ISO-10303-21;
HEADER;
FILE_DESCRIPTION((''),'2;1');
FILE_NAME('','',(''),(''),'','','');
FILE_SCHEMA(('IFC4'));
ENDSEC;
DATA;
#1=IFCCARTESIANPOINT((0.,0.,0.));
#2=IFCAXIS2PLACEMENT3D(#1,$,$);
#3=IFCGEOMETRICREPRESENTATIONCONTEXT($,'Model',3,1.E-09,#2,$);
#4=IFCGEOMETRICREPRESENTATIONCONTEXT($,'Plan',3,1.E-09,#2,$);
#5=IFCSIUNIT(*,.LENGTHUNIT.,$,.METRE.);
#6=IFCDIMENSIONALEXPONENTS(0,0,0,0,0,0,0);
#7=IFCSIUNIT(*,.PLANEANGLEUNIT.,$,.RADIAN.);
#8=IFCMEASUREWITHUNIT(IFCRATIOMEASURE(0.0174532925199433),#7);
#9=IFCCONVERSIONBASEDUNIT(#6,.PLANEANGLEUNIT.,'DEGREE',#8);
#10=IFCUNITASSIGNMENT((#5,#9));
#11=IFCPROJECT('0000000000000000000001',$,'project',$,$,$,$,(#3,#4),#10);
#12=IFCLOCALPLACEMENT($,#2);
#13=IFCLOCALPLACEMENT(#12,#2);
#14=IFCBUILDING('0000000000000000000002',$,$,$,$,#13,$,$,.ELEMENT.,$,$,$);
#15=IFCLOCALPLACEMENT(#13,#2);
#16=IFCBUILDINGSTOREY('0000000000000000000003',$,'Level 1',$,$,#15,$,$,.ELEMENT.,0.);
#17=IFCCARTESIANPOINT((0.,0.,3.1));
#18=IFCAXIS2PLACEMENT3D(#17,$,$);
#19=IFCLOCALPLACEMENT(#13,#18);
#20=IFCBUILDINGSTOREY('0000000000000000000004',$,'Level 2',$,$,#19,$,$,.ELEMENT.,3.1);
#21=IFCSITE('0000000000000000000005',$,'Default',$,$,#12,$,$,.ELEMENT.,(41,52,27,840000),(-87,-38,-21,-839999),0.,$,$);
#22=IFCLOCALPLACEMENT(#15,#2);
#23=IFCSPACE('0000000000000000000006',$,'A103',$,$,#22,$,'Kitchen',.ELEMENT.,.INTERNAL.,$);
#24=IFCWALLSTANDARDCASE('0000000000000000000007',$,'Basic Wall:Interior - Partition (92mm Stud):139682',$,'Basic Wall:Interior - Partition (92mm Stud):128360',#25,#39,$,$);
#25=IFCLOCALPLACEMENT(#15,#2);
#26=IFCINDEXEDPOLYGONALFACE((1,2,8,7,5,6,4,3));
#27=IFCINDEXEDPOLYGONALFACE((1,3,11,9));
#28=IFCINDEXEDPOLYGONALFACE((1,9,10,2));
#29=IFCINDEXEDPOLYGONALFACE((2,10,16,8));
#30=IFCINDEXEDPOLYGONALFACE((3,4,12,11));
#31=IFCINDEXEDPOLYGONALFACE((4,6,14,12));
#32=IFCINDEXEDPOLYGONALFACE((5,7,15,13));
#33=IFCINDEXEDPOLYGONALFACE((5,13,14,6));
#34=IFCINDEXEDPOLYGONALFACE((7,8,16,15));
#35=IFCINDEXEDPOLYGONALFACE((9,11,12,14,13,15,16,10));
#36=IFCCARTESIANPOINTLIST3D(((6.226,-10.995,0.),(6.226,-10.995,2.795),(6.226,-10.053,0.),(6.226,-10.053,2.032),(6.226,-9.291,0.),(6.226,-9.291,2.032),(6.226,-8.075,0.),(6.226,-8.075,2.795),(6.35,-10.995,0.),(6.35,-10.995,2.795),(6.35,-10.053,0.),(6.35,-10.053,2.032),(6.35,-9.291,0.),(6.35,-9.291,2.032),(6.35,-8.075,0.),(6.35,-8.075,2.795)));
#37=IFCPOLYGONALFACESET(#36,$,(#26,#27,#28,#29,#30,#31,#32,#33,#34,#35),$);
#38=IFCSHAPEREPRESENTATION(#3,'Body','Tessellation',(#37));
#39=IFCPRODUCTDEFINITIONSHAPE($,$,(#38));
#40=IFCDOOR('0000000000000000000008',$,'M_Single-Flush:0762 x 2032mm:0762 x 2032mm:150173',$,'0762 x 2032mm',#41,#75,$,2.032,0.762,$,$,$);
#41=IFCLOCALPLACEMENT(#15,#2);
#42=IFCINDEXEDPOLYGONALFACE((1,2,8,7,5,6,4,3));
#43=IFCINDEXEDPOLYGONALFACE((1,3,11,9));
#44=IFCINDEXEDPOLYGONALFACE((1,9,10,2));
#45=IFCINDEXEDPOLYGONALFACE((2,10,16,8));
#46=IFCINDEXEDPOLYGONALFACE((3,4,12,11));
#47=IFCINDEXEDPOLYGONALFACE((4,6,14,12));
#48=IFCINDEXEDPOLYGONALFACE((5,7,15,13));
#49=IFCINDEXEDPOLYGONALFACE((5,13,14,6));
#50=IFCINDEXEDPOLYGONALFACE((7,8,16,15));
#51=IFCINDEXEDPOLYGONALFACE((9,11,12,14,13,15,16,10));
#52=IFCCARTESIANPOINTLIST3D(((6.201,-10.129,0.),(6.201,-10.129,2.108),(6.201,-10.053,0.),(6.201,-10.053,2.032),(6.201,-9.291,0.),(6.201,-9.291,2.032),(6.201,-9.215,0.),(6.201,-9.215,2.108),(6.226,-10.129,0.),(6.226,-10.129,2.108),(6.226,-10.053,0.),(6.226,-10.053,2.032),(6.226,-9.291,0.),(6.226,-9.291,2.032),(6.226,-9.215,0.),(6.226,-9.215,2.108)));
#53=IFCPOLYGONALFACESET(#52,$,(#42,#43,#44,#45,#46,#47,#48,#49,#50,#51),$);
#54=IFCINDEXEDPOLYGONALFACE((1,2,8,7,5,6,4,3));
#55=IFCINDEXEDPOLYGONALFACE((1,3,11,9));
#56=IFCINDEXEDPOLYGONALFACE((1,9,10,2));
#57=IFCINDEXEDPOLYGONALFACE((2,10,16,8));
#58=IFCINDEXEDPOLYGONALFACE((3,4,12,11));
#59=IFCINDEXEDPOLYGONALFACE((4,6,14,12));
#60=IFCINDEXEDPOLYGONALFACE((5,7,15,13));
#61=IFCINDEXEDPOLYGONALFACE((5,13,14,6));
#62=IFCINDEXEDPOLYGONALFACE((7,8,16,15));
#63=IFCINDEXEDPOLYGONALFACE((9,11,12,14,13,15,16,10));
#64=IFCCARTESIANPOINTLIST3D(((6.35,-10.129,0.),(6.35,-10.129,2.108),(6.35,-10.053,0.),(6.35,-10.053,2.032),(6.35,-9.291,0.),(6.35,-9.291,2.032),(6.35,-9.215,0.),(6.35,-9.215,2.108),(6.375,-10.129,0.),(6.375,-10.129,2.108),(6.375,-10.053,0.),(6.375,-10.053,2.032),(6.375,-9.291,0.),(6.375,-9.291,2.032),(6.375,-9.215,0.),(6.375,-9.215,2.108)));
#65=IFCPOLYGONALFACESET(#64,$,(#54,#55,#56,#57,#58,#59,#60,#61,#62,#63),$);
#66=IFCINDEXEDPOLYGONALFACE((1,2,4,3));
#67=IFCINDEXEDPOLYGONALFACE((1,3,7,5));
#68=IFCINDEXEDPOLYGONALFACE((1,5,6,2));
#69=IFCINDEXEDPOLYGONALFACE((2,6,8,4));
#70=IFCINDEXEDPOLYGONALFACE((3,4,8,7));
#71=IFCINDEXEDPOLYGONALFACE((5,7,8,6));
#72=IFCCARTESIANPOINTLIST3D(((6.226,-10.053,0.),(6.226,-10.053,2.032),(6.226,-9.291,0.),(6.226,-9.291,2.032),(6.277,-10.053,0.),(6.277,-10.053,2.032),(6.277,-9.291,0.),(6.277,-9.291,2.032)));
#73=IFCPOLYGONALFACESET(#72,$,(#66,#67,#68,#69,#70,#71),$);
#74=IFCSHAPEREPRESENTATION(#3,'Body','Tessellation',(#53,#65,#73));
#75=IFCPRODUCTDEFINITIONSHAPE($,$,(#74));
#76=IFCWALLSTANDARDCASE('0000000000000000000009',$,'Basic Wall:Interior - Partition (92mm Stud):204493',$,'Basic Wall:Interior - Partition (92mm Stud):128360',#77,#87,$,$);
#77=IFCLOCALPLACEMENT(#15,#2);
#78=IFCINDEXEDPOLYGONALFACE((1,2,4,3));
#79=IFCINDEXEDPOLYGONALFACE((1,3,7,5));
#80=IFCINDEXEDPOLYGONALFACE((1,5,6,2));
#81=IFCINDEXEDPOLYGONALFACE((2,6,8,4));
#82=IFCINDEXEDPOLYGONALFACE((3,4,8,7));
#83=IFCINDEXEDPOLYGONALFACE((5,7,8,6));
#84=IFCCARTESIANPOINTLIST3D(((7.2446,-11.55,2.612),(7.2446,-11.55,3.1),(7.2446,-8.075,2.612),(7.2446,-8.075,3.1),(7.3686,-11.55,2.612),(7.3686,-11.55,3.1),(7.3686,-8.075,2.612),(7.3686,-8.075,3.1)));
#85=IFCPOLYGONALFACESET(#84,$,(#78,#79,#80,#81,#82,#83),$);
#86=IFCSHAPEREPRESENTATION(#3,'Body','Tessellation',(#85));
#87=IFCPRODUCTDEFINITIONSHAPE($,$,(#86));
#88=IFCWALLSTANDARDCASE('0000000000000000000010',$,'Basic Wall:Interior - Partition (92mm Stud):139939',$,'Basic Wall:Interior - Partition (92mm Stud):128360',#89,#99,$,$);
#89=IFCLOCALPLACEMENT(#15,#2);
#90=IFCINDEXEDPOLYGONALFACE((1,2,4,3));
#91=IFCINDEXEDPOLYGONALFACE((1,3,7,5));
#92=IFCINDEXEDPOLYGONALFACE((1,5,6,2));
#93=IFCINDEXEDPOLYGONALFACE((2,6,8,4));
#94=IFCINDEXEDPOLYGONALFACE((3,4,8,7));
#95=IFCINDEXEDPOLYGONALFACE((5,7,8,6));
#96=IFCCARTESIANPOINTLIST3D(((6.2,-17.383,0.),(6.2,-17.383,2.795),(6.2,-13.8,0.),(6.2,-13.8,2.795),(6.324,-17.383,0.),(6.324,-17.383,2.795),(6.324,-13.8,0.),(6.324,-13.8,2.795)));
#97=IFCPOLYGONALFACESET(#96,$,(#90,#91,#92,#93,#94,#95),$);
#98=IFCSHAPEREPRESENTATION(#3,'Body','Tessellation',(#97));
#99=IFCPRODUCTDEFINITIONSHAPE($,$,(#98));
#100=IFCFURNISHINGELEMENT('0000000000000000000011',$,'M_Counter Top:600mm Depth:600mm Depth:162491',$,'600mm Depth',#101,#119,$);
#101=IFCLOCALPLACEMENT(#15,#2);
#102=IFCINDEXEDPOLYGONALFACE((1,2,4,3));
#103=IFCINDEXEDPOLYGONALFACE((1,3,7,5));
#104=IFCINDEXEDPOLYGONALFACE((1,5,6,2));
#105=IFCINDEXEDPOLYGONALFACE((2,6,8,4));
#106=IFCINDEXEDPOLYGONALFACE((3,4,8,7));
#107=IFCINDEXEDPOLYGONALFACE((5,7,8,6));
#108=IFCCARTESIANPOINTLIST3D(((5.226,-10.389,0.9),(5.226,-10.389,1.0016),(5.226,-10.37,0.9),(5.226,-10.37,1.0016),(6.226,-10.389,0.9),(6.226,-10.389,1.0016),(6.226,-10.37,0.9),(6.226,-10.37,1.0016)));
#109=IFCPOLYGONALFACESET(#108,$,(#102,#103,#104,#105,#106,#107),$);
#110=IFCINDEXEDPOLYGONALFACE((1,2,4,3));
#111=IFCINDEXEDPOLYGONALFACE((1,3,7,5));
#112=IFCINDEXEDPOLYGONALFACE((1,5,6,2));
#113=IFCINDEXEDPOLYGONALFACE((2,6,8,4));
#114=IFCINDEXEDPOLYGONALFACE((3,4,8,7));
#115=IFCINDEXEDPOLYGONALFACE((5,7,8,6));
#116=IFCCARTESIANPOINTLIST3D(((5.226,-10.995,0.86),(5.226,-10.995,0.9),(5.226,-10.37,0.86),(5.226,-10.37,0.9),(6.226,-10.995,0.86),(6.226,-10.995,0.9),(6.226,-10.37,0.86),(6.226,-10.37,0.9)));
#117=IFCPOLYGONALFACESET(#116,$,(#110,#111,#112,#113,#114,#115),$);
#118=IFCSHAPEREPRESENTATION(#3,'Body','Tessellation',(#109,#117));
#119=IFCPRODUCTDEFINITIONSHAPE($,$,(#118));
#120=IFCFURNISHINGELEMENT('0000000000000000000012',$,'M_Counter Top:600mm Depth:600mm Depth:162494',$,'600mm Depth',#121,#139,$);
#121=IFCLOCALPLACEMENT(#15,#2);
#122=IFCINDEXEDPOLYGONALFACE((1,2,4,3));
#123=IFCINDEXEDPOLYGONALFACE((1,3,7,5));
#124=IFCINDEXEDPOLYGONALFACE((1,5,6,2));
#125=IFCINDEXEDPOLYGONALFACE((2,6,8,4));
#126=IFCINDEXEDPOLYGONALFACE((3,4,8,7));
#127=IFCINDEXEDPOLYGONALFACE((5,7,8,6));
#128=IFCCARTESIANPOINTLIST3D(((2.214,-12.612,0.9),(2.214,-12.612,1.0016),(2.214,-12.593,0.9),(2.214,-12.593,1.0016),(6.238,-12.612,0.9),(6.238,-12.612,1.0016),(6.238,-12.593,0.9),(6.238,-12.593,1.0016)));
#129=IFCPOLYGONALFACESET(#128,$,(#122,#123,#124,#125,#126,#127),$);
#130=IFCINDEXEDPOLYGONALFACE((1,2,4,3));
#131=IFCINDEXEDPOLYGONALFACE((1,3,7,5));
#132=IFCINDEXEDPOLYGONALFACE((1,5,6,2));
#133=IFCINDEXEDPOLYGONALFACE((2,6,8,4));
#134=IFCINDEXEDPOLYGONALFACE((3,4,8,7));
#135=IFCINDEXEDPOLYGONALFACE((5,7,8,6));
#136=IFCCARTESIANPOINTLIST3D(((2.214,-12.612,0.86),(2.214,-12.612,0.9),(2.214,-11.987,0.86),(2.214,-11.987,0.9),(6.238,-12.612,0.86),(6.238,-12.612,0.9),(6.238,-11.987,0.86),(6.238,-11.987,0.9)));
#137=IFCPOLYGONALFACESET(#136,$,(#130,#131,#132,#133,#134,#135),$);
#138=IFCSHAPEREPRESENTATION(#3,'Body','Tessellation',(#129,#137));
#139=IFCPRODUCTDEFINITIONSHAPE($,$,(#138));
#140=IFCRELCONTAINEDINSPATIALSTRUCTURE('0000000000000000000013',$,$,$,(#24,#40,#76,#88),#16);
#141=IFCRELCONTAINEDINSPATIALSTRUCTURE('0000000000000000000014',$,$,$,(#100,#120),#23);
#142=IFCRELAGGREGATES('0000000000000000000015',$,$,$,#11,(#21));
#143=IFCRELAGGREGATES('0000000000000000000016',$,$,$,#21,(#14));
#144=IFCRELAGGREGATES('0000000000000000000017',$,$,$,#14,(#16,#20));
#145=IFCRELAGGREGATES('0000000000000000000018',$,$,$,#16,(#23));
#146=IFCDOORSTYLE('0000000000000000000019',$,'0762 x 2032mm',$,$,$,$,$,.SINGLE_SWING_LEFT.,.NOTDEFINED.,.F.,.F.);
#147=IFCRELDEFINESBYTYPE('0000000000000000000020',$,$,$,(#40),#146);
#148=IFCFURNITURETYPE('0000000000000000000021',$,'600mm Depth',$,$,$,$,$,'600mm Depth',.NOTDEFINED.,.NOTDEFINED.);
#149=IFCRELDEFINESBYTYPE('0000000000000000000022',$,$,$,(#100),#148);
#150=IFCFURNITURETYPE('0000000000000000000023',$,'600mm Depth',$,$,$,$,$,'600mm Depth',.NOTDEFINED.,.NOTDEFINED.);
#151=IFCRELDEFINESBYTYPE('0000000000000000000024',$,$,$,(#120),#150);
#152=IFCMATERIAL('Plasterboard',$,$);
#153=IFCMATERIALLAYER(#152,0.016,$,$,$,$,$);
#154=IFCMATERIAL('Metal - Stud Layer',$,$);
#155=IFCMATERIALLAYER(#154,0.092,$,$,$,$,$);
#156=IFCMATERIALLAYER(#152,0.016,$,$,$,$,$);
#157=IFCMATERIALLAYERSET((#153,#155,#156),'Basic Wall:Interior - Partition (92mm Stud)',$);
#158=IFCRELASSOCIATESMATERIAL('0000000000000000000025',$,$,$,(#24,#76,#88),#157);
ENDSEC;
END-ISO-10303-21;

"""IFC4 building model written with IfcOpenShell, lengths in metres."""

from ifc_helpers import new_model, entity, si_unit, converted_unit, frame, frame_2d, origin, origin_2d_with_axis, place, context, project, spatial, polyline, rectangle, outline, extrude, source, transform, mapped, material, layer, layer_set, layer_usage, type_object, type_shapes, element, fill, save


model = new_model("IFC4")

# Units and contexts
model_context = context("Model", 3, precision=1e-09, world=origin())
plan_context = context("Plan", 3, precision=1e-09, world=origin())
ifc_project = project(units=[si_unit("LENGTHUNIT", "METRE"), converted_unit("PLANEANGLEUNIT", "DEGREE", entity("IfcRatioMeasure", 0.0174532925199433), si_unit("PLANEANGLEUNIT", "RADIAN"), dimensions=[0, 0, 0, 0, 0, 0, 0])], contexts=[model_context, plan_context])

# Site, building, storey
site_placement = place(None, origin())
site = spatial("IfcSite", under=ifc_project, at=site_placement, Name="Default", CompositionType="ELEMENT", RefLatitude=(41, 52, 27, 840000), RefLongitude=(-87, -38, -21, -839999), RefElevation=0.0)
building_placement = place(site_placement, origin())
building = spatial("IfcBuilding", under=site, at=building_placement, CompositionType="ELEMENT")
storey_1_placement = place(building_placement, origin())
storey_1 = spatial("IfcBuildingStorey", under=building, at=storey_1_placement, Name="Level 1", CompositionType="ELEMENT", Elevation=0.0)

# Shared definitions
ifc_material_1 = material(Name="Metal - Stud Layer")
ifc_material_2 = material(Name="Plasterboard")

# Shared definitions
ifc_layer_1 = layer(ifc_material_2, 0.016)
ifc_layer_2 = layer(ifc_material_1, 0.092)
ifc_layer_3 = layer(ifc_material_2, 0.016)
ifc_layer_set_1 = layer_set([ifc_layer_1, ifc_layer_2, ifc_layer_3], Name="Basic Wall:Interior - Partition (92mm Stud)")

# Wall, opening, door
ifc_layer_usage_1 = layer_usage(ifc_layer_set_1, "AXIS2", "NEGATIVE", 0.062)
wall_1_placement = place(storey_1_placement, frame((6.288, -10.995, 0.0), z_axis=(0.0, 0.0, 1.0), x_axis=(0.0, 1.0, 0.0)))
wall_1 = element("IfcWallStandardCase", 1, at=wall_1_placement, inside=storey_1, material=ifc_layer_usage_1, Name="Basic Wall:Interior - Partition (92mm Stud):139682", ObjectType="Basic Wall:Interior - Partition (92mm Stud):128360", context=model_context, shape_type="SweptSolid", body=[
    extrude(rectangle(XDim=2.92, YDim=0.124, at=frame_2d((1.46, 0.0), x_axis=(-1.0, 0.0))), origin(), (0.0, 0.0, 1.0), 2.795),
])
opening_1_placement = place(wall_1_placement, frame((0.942, -0.062, 0.0)))
opening_1 = element("IfcOpeningElement", 2, at=opening_1_placement, cuts=wall_1, ObjectType="Opening", context=model_context, shape_type="SweptSolid", body=[
    extrude(rectangle(XDim=0.762, YDim=2.032, at=frame_2d((1.016, 0.381), x_axis=(0.0, -1.0))), frame((0.0, 0.0, 0.0), z_axis=(0.0, 1.0, 0.0), x_axis=(0.0, 0.0, 1.0)), (0.0, 0.0, 1.0), 0.124),
])
door_style_1 = type_object("IfcDoorStyle", Name="0762 x 2032mm", ConstructionType="NOTDEFINED", OperationType="SINGLE_SWING_LEFT", ParameterTakesPrecedence=False, Sizeable=False)
shared_shape_1 = source(origin(), model_context, "Body", "SweptSolid", [
    extrude(outline(polyline([(-0.457, -1.073), (0.457, -1.073), (0.457, 1.035), (0.381, 1.035), (0.381, -0.997), (-0.381, -0.997), (-0.381, 1.035), (-0.457, 1.035), (-0.457, -1.073)])), frame((0.381, 0.149, 1.035), z_axis=(0.0, -1.0, 0.0), x_axis=(-1.0, 0.0, 0.0)), (0.0, 0.0, 1.0), 0.025),
    extrude(outline(polyline([(-1.073, -0.457), (1.035, -0.457), (1.035, -0.381), (-0.997, -0.381), (-0.997, 0.381), (1.035, 0.381), (1.035, 0.457), (-1.073, 0.457), (-1.073, -0.457)])), frame((0.381, 0.0, 1.035), z_axis=(0.0, -1.0, 0.0), x_axis=(0.0, 0.0, -1.0)), (0.0, 0.0, 1.0), 0.025),
    extrude(rectangle(XDim=0.762, YDim=0.051, at=origin_2d_with_axis()), frame((0.381, 0.0985, 0.0)), (0.0, 0.0, 1.0), 2.032),
])
type_shapes(door_style_1, [shared_shape_1])
door_1_placement = place(opening_1_placement, origin())
door_1 = element("IfcDoor", 3, at=door_1_placement, inside=storey_1, type_object=door_style_1, Name="M_Single-Flush:0762 x 2032mm:0762 x 2032mm:150173", ObjectType="0762 x 2032mm", OverallHeight=2.032, OverallWidth=0.762, context=model_context, shape_type="MappedRepresentation", body=[
    mapped(shared_shape_1, transform((0.0, 0.0, 0.0), scale=1.0)),
])
fill(opening_1, door_1)

# Shared definitions
storey_2_placement = place(building_placement, frame((0.0, 0.0, 3.1)))
storey_2 = spatial("IfcBuildingStorey", under=building, at=storey_2_placement, Name="Level 2", CompositionType="ELEMENT", Elevation=3.1)

# Walls
ifc_layer_usage_2 = layer_usage(ifc_layer_set_1, "AXIS2", "NEGATIVE", 0.062)
wall_2_placement = place(storey_1_placement, frame((7.3066, -11.55, 2.612), z_axis=(0.0, 0.0, 1.0), x_axis=(0.0, 1.0, 0.0)))
element("IfcWallStandardCase", 4, at=wall_2_placement, inside=storey_1, material=ifc_layer_usage_2, Name="Basic Wall:Interior - Partition (92mm Stud):204493", ObjectType="Basic Wall:Interior - Partition (92mm Stud):128360", context=model_context, shape_type="SweptSolid", body=[
    extrude(rectangle(XDim=3.475, YDim=0.124, at=frame_2d((1.7375, 0.0), x_axis=(-1.0, 0.0))), origin(), (0.0, 0.0, 1.0), 0.488),
])
ifc_layer_usage_3 = layer_usage(ifc_layer_set_1, "AXIS2", "NEGATIVE", 0.062)
wall_3_placement = place(storey_1_placement, frame((6.262, -13.8, 0.0), z_axis=(0.0, 0.0, 1.0), x_axis=(0.0, -1.0, 0.0)))
element("IfcWallStandardCase", 5, at=wall_3_placement, inside=storey_1, material=ifc_layer_usage_3, Name="Basic Wall:Interior - Partition (92mm Stud):139939", ObjectType="Basic Wall:Interior - Partition (92mm Stud):128360", context=model_context, shape_type="SweptSolid", body=[
    extrude(rectangle(XDim=3.583, YDim=0.124, at=frame_2d((1.7915, 0.0), x_axis=(-1.0, 0.0))), origin(), (0.0, 0.0, 1.0), 2.795),
])

# Shared definitions
space_1_placement = place(storey_1_placement, origin())
space_1 = spatial("IfcSpace", under=storey_1, at=space_1_placement, Name="A103", LongName="Kitchen", CompositionType="ELEMENT", PredefinedType="INTERNAL")

# Furnishing elements
furniture_type_1 = type_object("IfcFurnitureType", Name="600mm Depth", ElementType="600mm Depth", AssemblyPlace="NOTDEFINED")
shared_shape_2 = source(origin(), model_context, "Body", "SweptSolid", [
    extrude(rectangle(XDim=0.0191, YDim=1.0, at=origin_2d_with_axis()), frame((-0.7005, -0.0095, 0.9), z_axis=(0.0, 0.0, 1.0), x_axis=(0.0, -1.0, 0.0)), (0.0, 0.0, 1.0), 0.1016),
    extrude(rectangle(XDim=1.0, YDim=0.625, at=origin_2d_with_axis()), frame((-0.7005, -0.3125, 0.86), z_axis=(0.0, 0.0, 1.0), x_axis=(-1.0, 0.0, 0.0)), (0.0, 0.0, 1.0), 0.04),
])
type_shapes(furniture_type_1, [shared_shape_2])
furnishing_1_placement = place(space_1_placement, frame((6.4265, -10.37, 0.0)))
element("IfcFurnishingElement", 6, at=furnishing_1_placement, inside=space_1, type_object=furniture_type_1, Name="M_Counter Top:600mm Depth:600mm Depth:162491", ObjectType="600mm Depth", context=model_context, shape_type="MappedRepresentation", body=[
    mapped(shared_shape_2, transform((0.0, 0.0, 0.0), scale=1.0)),
])
furniture_type_2 = type_object("IfcFurnitureType", Name="600mm Depth", ElementType="600mm Depth", AssemblyPlace="NOTDEFINED")
shared_shape_3 = source(origin(), model_context, "Body", "SweptSolid", [
    extrude(rectangle(XDim=0.0191, YDim=4.024, at=origin_2d_with_axis()), frame((0.8115, -0.0095, 0.9), z_axis=(0.0, 0.0, 1.0), x_axis=(0.0, -1.0, 0.0)), (0.0, 0.0, 1.0), 0.1016),
    extrude(rectangle(XDim=4.024, YDim=0.625, at=origin_2d_with_axis()), frame((0.8115, -0.3125, 0.86), z_axis=(0.0, 0.0, 1.0), x_axis=(-1.0, 0.0, 0.0)), (0.0, 0.0, 1.0), 0.04),
])
type_shapes(furniture_type_2, [shared_shape_3])
furnishing_2_placement = place(space_1_placement, frame((5.0375, -12.612, 0.0), z_axis=(0.0, 0.0, 1.0), x_axis=(-1.0, 0.0, 0.0)))
element("IfcFurnishingElement", 7, at=furnishing_2_placement, inside=space_1, type_object=furniture_type_2, Name="M_Counter Top:600mm Depth:600mm Depth:162494", ObjectType="600mm Depth", context=model_context, shape_type="MappedRepresentation", body=[
    mapped(shared_shape_3, transform((0.0, 0.0, 0.0), scale=1.0)),
])

save(model, "model.ifc")
